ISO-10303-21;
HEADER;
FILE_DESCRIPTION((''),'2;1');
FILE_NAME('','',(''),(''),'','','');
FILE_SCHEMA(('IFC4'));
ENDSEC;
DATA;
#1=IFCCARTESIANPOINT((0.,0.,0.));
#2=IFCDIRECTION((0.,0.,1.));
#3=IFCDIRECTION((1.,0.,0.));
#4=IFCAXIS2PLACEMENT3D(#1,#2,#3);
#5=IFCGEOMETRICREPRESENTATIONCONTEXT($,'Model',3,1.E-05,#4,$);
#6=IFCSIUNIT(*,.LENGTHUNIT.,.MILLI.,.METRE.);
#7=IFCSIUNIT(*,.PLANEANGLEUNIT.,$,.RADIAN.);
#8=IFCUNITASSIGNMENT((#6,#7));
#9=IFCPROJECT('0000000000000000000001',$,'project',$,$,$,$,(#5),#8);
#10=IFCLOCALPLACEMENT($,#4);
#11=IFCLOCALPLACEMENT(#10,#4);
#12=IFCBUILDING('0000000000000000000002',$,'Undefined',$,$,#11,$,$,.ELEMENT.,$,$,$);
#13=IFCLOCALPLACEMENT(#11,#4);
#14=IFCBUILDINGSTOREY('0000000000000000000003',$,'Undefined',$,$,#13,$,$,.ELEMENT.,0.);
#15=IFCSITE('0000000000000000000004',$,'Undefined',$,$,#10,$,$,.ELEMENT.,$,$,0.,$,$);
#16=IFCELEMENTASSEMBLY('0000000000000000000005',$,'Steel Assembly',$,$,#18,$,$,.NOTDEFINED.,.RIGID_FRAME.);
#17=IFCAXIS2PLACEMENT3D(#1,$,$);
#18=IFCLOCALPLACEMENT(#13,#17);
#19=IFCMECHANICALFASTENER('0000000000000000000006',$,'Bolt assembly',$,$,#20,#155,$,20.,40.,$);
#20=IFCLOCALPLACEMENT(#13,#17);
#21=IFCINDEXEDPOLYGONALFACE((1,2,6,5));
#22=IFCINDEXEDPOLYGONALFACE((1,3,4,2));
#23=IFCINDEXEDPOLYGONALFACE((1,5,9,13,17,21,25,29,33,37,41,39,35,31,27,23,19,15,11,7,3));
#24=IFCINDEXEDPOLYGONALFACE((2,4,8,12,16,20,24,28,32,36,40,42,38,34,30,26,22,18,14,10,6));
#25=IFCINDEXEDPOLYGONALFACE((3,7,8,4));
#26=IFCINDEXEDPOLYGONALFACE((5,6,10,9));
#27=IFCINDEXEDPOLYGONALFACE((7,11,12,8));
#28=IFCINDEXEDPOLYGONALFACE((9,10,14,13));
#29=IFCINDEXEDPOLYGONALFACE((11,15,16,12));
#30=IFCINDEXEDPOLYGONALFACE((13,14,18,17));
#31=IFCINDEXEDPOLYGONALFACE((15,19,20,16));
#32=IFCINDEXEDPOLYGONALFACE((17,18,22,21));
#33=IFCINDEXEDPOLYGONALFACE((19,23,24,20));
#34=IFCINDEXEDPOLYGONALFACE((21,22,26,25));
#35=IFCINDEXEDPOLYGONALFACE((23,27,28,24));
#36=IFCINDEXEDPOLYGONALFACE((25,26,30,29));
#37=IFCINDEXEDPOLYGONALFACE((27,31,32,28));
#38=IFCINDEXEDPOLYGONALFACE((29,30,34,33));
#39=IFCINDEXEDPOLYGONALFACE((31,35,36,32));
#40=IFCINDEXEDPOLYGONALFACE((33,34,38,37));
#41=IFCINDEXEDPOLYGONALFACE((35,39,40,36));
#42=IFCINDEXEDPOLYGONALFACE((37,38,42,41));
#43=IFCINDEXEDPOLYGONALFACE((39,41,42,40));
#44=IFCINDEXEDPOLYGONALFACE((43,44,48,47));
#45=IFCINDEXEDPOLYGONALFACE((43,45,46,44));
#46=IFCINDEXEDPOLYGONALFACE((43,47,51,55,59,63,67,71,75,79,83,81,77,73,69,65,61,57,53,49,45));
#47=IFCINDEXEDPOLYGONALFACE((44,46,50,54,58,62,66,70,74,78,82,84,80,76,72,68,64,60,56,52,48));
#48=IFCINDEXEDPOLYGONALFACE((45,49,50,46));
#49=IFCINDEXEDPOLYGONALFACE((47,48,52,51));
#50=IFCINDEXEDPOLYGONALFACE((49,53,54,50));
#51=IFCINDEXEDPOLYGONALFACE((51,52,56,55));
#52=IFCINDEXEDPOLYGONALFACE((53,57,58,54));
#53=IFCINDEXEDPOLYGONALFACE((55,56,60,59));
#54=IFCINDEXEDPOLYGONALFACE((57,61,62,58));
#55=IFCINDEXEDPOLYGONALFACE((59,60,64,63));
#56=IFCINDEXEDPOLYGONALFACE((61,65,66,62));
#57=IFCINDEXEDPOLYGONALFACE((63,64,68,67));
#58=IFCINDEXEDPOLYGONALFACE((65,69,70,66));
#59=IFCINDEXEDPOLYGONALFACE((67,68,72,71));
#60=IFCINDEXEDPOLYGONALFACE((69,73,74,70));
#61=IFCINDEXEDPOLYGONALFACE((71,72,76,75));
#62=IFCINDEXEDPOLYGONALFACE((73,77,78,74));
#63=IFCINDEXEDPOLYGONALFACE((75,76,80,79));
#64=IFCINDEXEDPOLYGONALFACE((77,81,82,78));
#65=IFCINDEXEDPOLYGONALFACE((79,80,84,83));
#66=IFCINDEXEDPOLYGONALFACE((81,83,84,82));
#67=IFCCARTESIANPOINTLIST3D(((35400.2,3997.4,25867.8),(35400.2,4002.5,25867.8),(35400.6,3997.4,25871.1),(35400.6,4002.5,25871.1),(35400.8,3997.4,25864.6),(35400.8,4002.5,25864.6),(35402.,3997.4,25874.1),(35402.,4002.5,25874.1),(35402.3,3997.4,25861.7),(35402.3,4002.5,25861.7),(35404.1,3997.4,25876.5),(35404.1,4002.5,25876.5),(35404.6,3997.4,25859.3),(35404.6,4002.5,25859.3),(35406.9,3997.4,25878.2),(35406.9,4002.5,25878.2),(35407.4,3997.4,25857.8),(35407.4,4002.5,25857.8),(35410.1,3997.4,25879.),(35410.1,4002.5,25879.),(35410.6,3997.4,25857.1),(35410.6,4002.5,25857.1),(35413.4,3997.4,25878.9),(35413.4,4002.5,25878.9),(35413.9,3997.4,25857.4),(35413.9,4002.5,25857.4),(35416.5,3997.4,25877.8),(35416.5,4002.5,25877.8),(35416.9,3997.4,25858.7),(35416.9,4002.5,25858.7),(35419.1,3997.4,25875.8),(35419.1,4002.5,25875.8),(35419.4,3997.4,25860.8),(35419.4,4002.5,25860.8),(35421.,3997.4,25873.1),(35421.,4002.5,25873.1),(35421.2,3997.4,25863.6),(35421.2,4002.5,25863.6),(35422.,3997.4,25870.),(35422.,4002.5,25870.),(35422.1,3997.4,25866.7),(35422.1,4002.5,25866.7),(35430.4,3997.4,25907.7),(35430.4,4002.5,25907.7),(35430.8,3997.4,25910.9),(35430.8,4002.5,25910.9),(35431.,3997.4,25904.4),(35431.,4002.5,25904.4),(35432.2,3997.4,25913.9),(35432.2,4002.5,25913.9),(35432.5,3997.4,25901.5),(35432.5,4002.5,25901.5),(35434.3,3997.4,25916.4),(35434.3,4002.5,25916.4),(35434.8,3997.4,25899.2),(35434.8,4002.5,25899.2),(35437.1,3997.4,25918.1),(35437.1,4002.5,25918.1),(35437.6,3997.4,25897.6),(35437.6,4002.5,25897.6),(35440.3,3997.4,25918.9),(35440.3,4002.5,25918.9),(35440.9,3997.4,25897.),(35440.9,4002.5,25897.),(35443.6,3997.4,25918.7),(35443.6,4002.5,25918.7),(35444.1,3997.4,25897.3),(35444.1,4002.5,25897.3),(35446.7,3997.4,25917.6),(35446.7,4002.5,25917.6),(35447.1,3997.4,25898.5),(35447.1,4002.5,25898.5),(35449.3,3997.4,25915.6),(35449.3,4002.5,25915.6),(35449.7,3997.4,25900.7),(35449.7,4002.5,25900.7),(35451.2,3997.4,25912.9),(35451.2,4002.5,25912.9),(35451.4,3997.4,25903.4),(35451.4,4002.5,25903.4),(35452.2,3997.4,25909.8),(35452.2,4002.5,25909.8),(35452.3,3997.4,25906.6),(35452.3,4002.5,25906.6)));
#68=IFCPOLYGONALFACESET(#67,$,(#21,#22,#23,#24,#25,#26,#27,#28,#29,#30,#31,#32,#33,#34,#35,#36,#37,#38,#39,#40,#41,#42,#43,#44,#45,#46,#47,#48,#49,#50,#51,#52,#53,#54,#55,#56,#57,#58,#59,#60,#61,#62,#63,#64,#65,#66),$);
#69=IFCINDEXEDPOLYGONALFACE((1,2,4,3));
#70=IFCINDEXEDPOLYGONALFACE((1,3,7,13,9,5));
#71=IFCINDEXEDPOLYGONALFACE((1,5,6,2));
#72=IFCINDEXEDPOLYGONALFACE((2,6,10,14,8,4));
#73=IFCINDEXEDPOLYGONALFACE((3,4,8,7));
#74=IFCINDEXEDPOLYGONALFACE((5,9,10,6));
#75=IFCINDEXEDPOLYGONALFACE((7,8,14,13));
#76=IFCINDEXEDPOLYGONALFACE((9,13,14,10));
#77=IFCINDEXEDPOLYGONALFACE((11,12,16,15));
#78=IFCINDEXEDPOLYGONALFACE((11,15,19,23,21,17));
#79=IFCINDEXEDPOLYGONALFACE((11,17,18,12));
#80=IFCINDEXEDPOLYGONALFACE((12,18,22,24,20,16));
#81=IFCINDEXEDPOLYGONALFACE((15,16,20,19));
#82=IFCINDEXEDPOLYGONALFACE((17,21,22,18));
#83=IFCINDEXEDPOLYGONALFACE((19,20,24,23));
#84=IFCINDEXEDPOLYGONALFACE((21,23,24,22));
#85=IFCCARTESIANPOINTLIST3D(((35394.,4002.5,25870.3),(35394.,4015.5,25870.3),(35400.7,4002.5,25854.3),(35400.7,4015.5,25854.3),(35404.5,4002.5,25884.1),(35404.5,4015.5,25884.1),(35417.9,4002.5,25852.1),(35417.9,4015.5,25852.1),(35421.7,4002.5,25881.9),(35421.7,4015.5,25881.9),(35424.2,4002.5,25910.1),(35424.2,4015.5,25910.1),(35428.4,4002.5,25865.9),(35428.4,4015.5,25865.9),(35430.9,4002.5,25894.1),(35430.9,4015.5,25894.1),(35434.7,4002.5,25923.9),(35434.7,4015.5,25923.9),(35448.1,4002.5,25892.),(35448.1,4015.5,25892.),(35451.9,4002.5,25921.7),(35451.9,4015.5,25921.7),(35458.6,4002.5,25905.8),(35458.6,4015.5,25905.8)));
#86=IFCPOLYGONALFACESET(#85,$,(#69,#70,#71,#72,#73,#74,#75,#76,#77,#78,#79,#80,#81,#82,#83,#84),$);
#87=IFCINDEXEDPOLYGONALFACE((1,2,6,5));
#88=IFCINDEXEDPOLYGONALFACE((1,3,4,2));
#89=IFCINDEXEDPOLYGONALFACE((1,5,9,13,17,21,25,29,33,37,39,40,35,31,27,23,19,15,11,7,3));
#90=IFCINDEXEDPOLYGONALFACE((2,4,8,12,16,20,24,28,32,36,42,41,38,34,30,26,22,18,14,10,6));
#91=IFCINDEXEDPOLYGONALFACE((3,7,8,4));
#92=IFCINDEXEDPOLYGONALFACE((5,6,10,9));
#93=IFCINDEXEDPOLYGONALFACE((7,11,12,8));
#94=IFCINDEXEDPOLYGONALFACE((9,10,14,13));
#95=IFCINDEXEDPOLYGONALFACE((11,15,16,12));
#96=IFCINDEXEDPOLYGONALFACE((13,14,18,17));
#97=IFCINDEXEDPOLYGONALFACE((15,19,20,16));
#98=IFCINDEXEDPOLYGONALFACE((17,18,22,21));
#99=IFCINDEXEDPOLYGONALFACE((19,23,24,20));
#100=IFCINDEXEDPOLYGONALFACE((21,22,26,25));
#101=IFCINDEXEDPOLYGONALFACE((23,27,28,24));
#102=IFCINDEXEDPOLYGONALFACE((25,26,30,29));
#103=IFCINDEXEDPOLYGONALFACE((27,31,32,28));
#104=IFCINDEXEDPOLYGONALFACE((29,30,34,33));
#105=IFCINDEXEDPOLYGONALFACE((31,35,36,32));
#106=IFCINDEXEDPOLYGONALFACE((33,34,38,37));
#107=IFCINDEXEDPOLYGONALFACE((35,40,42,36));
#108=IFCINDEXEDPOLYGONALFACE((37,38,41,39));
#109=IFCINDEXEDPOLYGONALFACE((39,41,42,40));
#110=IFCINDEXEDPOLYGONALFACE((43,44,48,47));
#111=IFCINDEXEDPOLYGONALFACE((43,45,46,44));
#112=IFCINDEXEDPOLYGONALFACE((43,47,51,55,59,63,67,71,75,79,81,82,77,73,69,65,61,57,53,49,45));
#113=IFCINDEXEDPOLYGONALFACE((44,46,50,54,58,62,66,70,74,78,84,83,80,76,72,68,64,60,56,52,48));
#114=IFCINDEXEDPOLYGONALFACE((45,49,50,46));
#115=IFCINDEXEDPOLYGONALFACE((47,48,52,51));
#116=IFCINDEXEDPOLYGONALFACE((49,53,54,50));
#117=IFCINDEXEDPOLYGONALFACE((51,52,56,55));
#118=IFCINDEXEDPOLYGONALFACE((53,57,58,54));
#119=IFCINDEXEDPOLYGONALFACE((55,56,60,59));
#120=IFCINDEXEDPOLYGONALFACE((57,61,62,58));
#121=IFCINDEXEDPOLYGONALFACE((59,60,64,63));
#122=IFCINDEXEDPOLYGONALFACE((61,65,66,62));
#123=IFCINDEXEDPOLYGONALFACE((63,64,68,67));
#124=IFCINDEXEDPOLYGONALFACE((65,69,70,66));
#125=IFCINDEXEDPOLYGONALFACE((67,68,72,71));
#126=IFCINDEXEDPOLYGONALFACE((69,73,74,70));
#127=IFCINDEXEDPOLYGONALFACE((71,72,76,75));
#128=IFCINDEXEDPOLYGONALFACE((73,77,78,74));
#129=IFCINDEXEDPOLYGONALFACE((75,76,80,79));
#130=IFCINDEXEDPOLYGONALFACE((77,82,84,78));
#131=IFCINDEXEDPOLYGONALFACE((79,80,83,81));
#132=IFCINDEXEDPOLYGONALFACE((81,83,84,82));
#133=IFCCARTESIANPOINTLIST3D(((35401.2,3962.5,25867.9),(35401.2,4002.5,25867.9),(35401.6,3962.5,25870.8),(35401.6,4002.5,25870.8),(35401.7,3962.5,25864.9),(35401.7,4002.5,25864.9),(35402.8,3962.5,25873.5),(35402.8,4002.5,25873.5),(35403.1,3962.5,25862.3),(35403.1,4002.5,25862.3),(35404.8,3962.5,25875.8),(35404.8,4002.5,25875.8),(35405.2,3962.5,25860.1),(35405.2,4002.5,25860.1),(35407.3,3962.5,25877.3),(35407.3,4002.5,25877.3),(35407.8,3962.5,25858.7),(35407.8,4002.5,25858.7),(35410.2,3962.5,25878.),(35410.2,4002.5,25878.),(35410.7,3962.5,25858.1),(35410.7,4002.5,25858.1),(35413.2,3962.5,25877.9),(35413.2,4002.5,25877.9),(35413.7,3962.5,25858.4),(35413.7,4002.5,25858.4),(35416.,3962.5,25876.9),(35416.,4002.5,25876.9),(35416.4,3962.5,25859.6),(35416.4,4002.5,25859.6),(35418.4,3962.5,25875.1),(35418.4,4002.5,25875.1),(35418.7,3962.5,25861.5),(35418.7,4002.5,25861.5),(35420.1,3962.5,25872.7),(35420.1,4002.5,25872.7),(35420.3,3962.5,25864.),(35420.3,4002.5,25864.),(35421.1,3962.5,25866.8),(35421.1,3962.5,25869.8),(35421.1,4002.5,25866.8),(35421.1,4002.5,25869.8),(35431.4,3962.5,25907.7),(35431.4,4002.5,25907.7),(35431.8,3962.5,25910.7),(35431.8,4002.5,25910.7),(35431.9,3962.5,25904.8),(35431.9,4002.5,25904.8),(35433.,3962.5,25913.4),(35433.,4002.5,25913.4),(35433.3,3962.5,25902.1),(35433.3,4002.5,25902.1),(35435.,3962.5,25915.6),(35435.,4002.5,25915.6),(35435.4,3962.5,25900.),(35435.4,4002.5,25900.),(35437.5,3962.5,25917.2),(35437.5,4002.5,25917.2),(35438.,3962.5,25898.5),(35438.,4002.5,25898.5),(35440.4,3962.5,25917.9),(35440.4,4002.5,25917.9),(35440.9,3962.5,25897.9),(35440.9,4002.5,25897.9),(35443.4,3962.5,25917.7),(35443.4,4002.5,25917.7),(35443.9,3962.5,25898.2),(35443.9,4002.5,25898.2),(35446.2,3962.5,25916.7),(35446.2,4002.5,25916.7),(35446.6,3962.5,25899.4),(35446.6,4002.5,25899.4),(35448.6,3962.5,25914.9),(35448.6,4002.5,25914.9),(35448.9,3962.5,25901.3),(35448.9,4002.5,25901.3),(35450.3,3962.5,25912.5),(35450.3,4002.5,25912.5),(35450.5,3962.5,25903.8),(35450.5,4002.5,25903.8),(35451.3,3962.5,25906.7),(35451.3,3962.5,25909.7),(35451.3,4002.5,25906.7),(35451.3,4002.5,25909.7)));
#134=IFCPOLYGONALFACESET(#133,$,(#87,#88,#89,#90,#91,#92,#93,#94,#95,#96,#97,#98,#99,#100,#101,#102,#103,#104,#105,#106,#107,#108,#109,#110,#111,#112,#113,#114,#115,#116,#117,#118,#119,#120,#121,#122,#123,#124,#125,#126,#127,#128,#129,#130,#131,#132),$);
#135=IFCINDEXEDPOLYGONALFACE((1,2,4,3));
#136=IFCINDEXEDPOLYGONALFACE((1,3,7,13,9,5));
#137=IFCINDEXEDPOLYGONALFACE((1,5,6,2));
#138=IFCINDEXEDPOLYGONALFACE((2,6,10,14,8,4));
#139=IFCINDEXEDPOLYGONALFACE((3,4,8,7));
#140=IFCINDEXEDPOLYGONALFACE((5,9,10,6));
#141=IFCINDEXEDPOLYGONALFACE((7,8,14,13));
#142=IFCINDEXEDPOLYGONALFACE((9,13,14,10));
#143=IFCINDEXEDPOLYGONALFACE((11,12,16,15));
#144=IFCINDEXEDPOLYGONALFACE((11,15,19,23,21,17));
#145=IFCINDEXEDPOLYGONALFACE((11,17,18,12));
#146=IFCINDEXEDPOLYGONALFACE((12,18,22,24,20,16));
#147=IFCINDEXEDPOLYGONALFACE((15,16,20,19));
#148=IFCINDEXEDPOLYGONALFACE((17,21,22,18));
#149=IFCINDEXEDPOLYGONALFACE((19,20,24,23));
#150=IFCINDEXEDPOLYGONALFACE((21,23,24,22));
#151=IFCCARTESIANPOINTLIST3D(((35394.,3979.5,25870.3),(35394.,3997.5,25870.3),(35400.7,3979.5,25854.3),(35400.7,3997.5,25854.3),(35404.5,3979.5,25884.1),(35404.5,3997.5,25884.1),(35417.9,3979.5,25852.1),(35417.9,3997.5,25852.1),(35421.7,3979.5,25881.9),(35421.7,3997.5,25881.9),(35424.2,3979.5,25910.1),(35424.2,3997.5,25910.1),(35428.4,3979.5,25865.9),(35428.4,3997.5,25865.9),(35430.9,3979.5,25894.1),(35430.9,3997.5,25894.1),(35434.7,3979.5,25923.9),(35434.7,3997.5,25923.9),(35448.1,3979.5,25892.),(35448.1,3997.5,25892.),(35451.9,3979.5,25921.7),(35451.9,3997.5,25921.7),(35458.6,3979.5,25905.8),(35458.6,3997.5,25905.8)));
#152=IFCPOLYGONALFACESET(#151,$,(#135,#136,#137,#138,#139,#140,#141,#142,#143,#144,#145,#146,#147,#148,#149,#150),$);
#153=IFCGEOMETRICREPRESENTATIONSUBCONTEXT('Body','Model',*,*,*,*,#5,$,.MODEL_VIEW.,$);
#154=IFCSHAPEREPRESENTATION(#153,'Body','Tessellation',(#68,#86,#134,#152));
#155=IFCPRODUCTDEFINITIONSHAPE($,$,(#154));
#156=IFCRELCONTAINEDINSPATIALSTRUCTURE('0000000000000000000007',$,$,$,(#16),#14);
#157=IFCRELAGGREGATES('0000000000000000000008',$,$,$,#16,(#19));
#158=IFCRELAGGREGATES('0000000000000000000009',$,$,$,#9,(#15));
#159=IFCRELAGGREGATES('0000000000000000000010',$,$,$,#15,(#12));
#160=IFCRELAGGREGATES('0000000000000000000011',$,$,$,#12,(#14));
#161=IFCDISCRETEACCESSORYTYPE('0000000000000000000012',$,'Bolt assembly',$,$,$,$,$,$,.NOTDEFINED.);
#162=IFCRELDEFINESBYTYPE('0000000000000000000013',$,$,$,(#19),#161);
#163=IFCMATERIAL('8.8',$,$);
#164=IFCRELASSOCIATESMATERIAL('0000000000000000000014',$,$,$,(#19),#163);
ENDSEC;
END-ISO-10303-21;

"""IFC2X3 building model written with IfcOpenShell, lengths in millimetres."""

from ifc_helpers import new_model, si_unit, frame, origin_with_axes, origin_2d_with_axis, place, context, subcontext, project, spatial, polyline, circle, outline, extrude, source, transform, mapped, material, type_object, element, aggregate, save


model = new_model("IFC2X3")

# Units and contexts
model_context = context("Model", 3, precision=1e-05, world=origin_with_axes())
body_context = subcontext(model_context, "Body", "Model", "MODEL_VIEW")
ifc_project = project(units=[si_unit("LENGTHUNIT", "METRE", prefix="MILLI"), si_unit("PLANEANGLEUNIT", "RADIAN")], contexts=[model_context])

# Site, building, storey
site_placement = place(None, origin_with_axes())
site = spatial("IfcSite", under=ifc_project, at=site_placement, Name="Undefined", CompositionType="ELEMENT", RefElevation=0.0)
building_placement = place(site_placement, origin_with_axes())
building = spatial("IfcBuilding", under=site, at=building_placement, Name="Undefined", CompositionType="ELEMENT")
storey_placement = place(building_placement, origin_with_axes())
storey = spatial("IfcBuildingStorey", under=building, at=storey_placement, Name="Undefined", CompositionType="ELEMENT", Elevation=0.0)

# Element assembly
assembly_1_placement = place(storey_placement, origin_with_axes())
assembly_1 = element("IfcElementAssembly", 1, at=assembly_1_placement, inside=storey, Name="Steel Assembly", AssemblyPlace="NOTDEFINED", PredefinedType="RIGID_FRAME")

# Shared definitions
discrete_accessory_type_1 = type_object("IfcDiscreteAccessoryType", Name="Bolt assembly")
ifc_material_1 = material(Name="8.8")

# Mechanical fastener
shared_shape_1 = source(origin_with_axes(), body_context, "Body", "SweptSolid", [
    extrude(circle(Radius=11.0, at=origin_2d_with_axis()), frame((0.0, -2.5, 0.0), z_axis=(0.0, 1.0, 0.0), x_axis=(1.0, 0.0, 0.0)), (0.0, 0.0, 1.0), 5.1),
    extrude(outline(polyline([(17.3, 0.0), (8.7, 15.0), (-8.7, 15.0), (-17.3, 0.0), (-8.7, -15.0), (8.7, -15.0), (17.3, 0.0)])), frame((0.0, -15.5, 0.0), z_axis=(0.0, 1.0, 0.0), x_axis=(1.0, 0.0, 0.0)), (0.0, 0.0, 1.0), 13.0),
    extrude(circle(Radius=10.0, at=origin_2d_with_axis()), frame((0.0, -2.5, 0.0), z_axis=(0.0, 1.0, 0.0), x_axis=(1.0, 0.0, 0.0)), (0.0, 0.0, 1.0), 40.0),
    extrude(outline(polyline([(17.3, 0.0), (8.7, 15.0), (-8.7, 15.0), (-17.3, 0.0), (-8.7, -15.0), (8.7, -15.0), (17.3, 0.0)])), frame((0.0, 2.5, 0.0), z_axis=(0.0, 1.0, 0.0), x_axis=(1.0, 0.0, 0.0)), (0.0, 0.0, 1.0), 18.0),
])
mechanical_fastener_1_placement = place(assembly_1_placement, frame((35441.4, 4000.0, 25907.9), z_axis=(-0.796808, 0.0, 0.604233), x_axis=(-0.604233, 0.0, -0.796808)))
mechanical_fastener_1 = element("IfcMechanicalFastener", 2, at=mechanical_fastener_1_placement, type_object=discrete_accessory_type_1, material=ifc_material_1, Name="Bolt assembly", NominalDiameter=20.0, NominalLength=40.0, context=body_context, shape_type="MappedRepresentation", body=[
    mapped(shared_shape_1, transform((0.0, 0.0, 0.0))),
    mapped(shared_shape_1, transform((50.0, 0.0, 0.0))),
])
aggregate(assembly_1, [mechanical_fastener_1])

save(model, "model.ifc")
